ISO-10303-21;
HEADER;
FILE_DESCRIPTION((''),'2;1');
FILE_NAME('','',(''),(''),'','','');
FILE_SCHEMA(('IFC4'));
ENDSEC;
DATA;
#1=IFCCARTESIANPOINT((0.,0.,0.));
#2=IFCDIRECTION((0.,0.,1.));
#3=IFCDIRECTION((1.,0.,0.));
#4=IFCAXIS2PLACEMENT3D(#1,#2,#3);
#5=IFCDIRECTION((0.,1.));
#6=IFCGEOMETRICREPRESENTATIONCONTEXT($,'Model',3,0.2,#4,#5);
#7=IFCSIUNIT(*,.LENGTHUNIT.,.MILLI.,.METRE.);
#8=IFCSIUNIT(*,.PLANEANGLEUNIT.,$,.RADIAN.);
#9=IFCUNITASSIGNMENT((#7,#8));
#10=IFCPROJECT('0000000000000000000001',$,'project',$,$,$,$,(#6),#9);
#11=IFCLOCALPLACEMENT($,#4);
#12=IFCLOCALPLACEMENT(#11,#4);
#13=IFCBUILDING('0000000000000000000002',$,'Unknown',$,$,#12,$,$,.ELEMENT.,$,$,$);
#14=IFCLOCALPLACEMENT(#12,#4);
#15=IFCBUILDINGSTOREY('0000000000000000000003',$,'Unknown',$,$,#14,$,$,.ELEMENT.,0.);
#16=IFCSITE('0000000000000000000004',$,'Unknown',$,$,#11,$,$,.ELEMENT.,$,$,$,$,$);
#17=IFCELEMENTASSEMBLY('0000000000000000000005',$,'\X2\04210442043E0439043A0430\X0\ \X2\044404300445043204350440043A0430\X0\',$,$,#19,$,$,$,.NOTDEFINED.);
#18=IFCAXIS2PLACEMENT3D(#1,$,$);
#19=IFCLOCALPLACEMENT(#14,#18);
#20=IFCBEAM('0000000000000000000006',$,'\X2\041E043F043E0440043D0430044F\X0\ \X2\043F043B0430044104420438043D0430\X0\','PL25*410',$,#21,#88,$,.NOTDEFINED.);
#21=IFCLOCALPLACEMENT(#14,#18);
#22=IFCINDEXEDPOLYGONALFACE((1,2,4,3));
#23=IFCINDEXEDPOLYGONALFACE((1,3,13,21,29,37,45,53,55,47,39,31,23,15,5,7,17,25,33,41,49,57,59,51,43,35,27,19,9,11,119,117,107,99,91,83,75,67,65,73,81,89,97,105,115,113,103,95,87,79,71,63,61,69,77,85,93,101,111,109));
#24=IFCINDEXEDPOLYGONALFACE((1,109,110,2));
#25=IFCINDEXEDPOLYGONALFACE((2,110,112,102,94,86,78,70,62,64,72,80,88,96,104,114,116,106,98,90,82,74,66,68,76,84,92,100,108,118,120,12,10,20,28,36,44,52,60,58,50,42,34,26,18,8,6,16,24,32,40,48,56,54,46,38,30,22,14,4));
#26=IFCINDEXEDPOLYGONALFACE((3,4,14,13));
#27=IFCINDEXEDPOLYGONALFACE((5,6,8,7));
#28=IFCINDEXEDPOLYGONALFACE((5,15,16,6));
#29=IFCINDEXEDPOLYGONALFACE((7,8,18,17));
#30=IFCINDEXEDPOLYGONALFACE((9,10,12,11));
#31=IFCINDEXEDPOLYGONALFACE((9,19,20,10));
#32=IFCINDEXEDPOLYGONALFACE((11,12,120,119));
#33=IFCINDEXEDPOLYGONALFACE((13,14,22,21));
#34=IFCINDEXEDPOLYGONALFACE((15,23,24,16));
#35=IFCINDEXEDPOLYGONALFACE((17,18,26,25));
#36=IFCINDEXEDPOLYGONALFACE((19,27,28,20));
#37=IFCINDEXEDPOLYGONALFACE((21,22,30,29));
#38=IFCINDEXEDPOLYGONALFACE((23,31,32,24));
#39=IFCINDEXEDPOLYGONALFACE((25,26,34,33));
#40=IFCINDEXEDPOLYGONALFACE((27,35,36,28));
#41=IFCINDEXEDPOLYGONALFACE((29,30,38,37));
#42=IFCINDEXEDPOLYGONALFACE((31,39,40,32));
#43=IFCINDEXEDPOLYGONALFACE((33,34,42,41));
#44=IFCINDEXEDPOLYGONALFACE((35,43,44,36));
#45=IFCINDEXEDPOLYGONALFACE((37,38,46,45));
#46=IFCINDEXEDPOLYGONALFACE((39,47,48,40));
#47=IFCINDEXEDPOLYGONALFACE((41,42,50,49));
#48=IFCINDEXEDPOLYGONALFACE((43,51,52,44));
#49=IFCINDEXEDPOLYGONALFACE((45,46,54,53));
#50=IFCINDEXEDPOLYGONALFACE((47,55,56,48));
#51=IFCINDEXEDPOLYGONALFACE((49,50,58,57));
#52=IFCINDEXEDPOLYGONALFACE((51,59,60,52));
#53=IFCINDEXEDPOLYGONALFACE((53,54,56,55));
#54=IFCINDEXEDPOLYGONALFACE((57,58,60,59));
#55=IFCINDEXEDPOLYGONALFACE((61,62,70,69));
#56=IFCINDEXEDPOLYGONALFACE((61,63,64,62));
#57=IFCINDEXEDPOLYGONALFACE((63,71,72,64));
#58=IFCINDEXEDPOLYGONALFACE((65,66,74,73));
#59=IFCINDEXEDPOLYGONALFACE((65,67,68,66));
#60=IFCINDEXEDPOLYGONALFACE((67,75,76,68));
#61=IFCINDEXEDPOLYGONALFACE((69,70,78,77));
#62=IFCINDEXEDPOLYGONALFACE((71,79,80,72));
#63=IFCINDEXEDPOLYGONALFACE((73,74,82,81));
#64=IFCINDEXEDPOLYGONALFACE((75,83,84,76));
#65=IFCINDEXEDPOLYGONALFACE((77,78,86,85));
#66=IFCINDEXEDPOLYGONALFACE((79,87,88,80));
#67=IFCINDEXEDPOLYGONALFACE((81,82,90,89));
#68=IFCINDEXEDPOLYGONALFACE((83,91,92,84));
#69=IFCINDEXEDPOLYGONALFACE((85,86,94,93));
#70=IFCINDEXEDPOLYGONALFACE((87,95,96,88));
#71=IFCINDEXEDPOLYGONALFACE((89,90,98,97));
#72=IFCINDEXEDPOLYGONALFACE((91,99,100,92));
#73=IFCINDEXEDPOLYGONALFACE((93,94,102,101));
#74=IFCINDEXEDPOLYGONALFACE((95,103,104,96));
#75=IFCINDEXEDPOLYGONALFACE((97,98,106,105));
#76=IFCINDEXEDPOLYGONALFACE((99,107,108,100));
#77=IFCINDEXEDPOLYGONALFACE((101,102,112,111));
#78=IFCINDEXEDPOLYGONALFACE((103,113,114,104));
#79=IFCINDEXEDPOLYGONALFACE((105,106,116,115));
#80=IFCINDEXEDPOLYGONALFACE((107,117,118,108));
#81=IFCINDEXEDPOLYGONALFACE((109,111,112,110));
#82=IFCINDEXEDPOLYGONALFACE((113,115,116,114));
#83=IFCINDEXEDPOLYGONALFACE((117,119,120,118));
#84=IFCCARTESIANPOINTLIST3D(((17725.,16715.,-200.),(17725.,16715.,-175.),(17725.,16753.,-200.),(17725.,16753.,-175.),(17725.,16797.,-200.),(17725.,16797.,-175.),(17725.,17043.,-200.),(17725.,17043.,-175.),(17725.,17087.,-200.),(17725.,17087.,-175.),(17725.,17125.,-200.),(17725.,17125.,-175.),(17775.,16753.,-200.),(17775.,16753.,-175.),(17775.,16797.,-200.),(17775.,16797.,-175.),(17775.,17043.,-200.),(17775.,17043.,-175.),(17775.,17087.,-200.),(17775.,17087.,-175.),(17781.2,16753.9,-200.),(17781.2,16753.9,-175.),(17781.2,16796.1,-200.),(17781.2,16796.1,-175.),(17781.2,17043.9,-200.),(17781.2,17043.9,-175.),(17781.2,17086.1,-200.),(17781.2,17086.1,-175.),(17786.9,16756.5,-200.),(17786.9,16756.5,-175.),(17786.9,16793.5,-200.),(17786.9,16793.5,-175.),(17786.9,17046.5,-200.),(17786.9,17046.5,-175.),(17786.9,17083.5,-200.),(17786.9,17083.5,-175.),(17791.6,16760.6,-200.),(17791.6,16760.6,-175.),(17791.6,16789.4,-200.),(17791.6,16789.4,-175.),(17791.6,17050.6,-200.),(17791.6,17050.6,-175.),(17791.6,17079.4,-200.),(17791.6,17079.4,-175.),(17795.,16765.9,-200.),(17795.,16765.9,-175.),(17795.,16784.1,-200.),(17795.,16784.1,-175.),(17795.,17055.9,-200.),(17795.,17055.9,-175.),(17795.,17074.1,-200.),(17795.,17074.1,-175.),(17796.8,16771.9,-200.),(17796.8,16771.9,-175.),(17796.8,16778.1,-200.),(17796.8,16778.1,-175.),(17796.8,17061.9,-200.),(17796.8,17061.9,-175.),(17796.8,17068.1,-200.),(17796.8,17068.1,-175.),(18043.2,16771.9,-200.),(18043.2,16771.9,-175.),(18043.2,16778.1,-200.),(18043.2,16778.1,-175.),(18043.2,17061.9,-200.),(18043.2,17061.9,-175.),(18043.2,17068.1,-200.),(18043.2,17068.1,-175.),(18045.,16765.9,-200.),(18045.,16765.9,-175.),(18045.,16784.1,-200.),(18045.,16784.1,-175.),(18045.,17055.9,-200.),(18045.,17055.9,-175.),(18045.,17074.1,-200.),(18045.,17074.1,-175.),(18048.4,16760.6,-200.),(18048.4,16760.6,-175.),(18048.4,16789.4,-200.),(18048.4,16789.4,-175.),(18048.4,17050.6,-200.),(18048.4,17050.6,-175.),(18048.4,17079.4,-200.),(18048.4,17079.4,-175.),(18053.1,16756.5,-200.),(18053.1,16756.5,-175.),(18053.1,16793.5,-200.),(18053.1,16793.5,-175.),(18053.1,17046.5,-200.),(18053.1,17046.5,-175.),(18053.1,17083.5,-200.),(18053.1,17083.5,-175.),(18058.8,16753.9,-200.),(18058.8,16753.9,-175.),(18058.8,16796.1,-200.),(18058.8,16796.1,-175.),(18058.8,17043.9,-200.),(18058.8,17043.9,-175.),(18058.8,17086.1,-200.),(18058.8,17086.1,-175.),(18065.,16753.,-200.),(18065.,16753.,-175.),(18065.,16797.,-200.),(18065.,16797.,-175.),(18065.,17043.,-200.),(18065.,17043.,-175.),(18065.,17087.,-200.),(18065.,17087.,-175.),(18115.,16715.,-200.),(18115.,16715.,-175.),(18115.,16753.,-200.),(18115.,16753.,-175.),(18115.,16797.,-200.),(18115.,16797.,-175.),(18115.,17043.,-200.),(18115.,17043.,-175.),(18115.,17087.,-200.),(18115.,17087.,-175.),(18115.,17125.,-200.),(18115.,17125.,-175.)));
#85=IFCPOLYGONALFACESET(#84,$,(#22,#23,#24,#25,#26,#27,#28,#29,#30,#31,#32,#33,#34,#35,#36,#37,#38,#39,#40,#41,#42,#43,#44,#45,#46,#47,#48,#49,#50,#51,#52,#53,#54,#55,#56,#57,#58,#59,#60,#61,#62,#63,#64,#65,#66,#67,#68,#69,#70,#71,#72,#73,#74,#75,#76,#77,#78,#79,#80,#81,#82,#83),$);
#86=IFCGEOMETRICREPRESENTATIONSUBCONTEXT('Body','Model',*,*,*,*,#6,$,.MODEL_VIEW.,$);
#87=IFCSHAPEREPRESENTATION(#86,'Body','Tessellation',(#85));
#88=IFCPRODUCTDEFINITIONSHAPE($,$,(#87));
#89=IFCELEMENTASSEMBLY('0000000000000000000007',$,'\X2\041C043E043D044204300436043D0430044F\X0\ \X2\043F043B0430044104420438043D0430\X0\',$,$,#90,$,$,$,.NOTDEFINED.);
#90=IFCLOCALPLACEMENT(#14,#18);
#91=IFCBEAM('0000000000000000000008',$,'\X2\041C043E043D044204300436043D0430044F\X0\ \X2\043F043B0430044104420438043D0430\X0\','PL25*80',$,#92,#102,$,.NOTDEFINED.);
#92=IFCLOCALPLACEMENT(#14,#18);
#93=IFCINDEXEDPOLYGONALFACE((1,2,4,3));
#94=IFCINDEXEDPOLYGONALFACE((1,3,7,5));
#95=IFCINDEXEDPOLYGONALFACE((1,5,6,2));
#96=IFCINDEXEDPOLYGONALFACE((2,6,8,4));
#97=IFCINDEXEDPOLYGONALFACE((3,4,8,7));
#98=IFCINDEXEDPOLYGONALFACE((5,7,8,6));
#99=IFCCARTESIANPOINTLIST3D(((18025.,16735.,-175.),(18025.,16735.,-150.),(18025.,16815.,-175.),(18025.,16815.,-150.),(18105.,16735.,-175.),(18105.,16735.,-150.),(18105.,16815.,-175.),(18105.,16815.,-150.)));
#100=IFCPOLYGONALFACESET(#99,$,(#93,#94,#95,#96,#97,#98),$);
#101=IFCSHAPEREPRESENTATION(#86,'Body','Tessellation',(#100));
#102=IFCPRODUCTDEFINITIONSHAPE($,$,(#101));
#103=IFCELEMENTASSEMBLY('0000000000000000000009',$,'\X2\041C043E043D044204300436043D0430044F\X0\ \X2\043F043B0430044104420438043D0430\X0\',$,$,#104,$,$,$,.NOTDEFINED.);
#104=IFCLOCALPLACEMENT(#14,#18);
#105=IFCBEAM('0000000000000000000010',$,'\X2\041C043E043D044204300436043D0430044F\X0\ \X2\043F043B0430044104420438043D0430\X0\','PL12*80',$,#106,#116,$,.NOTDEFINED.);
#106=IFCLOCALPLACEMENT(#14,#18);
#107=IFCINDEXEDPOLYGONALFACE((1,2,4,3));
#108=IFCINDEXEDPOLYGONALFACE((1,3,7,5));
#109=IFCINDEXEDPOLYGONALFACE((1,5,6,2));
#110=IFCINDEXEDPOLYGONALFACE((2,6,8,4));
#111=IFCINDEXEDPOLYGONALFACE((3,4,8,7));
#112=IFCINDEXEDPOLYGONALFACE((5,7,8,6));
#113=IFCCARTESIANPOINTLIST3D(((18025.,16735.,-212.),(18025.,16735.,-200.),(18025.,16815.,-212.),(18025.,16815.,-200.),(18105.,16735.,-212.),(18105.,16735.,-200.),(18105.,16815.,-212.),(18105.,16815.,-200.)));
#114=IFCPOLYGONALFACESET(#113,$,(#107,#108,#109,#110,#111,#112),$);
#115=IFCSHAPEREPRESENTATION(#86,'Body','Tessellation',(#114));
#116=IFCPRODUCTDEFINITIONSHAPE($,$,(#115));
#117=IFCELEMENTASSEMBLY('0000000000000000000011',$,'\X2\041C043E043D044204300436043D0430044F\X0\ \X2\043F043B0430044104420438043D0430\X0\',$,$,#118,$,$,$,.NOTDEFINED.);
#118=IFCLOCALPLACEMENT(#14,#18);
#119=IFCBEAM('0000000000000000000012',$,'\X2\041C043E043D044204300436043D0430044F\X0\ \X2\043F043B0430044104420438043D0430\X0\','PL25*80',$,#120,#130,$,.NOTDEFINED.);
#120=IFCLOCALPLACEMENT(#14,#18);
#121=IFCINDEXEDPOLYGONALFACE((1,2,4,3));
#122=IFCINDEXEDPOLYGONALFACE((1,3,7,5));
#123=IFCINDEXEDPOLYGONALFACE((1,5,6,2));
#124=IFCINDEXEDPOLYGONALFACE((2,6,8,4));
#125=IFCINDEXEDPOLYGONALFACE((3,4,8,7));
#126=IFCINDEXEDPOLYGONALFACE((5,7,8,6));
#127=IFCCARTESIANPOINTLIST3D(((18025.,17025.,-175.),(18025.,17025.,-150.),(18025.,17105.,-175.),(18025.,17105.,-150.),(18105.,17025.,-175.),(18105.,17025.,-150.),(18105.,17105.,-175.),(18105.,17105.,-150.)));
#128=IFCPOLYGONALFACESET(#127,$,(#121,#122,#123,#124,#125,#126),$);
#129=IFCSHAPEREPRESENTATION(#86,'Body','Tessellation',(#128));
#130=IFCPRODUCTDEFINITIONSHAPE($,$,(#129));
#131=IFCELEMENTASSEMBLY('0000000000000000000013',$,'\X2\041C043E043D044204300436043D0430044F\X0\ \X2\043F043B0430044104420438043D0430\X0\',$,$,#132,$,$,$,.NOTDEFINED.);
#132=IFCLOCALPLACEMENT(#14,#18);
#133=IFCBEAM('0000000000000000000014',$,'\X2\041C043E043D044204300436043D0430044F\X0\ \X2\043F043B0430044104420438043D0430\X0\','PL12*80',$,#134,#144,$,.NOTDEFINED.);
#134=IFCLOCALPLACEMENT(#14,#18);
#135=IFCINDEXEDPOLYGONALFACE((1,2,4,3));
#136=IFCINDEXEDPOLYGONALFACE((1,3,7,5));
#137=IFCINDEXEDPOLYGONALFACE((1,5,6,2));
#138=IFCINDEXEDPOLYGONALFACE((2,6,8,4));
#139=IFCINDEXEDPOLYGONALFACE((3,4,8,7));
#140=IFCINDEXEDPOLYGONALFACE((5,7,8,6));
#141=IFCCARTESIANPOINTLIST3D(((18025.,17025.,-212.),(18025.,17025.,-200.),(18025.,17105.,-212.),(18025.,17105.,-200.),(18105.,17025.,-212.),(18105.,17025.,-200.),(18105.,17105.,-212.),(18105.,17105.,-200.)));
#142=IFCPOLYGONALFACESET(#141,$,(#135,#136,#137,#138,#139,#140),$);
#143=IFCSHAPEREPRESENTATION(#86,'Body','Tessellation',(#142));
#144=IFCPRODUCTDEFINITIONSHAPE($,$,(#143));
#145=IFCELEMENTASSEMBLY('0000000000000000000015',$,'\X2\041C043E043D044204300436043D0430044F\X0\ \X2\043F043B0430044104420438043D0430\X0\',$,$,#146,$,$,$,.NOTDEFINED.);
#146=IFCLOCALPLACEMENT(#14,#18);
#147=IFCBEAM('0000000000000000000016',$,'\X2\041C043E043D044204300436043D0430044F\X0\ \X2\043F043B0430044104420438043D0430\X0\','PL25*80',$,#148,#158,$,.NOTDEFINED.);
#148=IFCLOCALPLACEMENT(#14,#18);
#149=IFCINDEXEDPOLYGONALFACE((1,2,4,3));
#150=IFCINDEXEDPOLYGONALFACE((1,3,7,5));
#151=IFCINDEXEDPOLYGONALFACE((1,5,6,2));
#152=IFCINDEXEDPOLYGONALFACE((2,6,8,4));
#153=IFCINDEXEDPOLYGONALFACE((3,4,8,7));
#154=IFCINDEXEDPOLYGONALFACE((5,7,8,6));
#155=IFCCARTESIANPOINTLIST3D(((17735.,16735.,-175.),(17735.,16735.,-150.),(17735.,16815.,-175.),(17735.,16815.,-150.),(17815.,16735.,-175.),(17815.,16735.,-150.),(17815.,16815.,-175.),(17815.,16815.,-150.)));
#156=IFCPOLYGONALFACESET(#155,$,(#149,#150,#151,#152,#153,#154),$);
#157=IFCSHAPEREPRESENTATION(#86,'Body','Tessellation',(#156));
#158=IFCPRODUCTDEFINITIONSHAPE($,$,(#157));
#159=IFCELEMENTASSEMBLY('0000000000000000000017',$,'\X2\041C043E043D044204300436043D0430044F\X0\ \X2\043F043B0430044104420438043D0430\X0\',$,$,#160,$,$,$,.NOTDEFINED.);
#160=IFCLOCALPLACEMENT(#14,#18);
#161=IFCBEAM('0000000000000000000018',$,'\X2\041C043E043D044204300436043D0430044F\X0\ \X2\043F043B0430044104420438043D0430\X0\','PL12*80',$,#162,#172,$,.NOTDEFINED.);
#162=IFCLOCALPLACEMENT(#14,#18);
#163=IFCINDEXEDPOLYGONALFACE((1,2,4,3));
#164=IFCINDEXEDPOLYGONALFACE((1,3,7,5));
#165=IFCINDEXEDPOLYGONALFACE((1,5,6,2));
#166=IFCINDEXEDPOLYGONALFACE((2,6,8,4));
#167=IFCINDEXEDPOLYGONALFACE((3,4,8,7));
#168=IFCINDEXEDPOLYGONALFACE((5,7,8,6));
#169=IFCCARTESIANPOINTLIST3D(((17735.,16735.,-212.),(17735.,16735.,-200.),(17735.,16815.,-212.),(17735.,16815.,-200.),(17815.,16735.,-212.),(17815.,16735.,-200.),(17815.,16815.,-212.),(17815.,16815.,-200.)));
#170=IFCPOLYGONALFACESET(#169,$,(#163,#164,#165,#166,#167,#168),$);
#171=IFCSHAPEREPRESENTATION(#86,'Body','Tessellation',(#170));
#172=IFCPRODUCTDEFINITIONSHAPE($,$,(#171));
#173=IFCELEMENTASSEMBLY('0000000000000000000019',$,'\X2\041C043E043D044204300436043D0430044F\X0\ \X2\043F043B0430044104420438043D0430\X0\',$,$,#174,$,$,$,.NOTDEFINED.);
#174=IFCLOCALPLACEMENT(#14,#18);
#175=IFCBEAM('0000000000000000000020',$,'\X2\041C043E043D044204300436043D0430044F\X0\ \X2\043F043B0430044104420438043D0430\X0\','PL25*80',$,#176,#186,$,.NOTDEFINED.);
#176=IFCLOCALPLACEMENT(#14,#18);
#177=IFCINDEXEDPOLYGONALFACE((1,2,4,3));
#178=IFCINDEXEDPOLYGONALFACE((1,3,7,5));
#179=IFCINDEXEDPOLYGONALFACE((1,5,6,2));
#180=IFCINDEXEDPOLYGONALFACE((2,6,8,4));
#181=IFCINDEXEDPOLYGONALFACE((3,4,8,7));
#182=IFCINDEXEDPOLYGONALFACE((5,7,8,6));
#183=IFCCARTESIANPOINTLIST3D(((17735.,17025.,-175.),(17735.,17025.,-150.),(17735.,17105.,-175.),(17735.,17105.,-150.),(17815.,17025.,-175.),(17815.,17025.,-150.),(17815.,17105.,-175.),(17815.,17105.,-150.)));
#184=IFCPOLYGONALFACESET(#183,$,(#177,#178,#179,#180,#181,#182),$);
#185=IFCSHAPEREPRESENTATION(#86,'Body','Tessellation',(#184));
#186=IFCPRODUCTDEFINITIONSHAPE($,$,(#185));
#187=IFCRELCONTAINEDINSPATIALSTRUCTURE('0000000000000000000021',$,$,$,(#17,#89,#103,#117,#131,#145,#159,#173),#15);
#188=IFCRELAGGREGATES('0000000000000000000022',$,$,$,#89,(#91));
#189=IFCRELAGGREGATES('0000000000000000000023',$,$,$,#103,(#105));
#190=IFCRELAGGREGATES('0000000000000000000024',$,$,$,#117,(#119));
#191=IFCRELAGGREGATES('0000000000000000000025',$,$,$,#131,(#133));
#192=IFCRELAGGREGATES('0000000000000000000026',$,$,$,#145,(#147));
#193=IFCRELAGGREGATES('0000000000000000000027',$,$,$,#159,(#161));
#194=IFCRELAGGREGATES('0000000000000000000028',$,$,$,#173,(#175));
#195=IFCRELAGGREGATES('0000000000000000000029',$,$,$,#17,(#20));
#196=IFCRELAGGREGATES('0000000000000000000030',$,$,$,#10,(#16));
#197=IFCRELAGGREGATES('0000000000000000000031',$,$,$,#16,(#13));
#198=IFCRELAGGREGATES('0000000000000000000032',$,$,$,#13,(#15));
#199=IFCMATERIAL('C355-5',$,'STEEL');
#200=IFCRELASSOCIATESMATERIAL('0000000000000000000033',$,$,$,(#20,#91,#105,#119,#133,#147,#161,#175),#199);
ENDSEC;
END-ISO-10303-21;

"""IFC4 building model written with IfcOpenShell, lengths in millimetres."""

from ifc_helpers import new_model, si_unit, direction, frame, origin_with_axes, place, context, subcontext, project, spatial, line, arc, indexed_curve, outline, extrude, material, element, aggregate, save


model = new_model("IFC4")

# Units and contexts
model_context = context("Model", 3, precision=0.2, world=origin_with_axes(), true_north=direction((0.0, 1.0)))
body_context = subcontext(model_context, "Body", "Model", "MODEL_VIEW")
ifc_project = project(units=[si_unit("LENGTHUNIT", "METRE", prefix="MILLI"), si_unit("PLANEANGLEUNIT", "RADIAN")], contexts=[model_context])

# Site, building, storey
site_placement = place(None, origin_with_axes())
site = spatial("IfcSite", under=ifc_project, at=site_placement, Name="Unknown", CompositionType="ELEMENT")
building_placement = place(site_placement, origin_with_axes())
building = spatial("IfcBuilding", under=site, at=building_placement, Name="Unknown", CompositionType="ELEMENT")
storey_placement = place(building_placement, origin_with_axes())
storey = spatial("IfcBuildingStorey", under=building, at=storey_placement, Name="Unknown", CompositionType="ELEMENT", Elevation=0.0)

# Shared definitions
ifc_material_1 = material(Name="C355-5", Category="STEEL")

# Element assembly, beam, voiding features
assembly_1_placement = place(storey_placement, frame((17920.0, 16920.0, -200.0), z_axis=(0.0, -1.0, 0.0), x_axis=(0.0, 0.0, 1.0)))
assembly_1 = element("IfcElementAssembly", 1, at=assembly_1_placement, inside=storey, Name="Стойка фахверка", PredefinedType="NOTDEFINED")
beam_1_placement = place(assembly_1_placement, frame((12.5, 195.0, 0.0), z_axis=(-1.0, 0.0, 0.0), x_axis=(0.0, -1.0, 0.0)))
beam_1 = element("IfcBeam", 2, at=beam_1_placement, material=ifc_material_1, Name="Опорная пластина", Description="PL25*410", PredefinedType="NOTDEFINED", context=body_context, shape_type="SolidModel", body=[
    extrude(outline(indexed_curve([(-12.5, -205.0), (12.5, -205.0), (12.5, 205.0), (-12.5, 205.0)], segments=[line(1, 2, 3, 4, 1)])), frame((0.0, 0.0, 0.0), z_axis=(-1.0, 0.0, 0.0), x_axis=(0.0, 0.0, 1.0)), (0.0, 0.0, -1.0), 390.0),
])
voiding_feature_1_placement = place(beam_1_placement, frame((390.0, 167.0, 0.0), z_axis=(0.0, 0.0, -1.0), x_axis=(0.0, -1.0, 0.0)))
element("IfcVoidingFeature", 3, at=voiding_feature_1_placement, cuts=beam_1, Name="Пластина", PredefinedType="HOLE", context=body_context, shape_type="SolidModel", body=[
    extrude(outline(indexed_curve([(0.0, 0.0), (44.0, 0.0), (44.0, 50.0), (37.6, 65.6), (22.0, 72.0), (22.0, 72.0), (6.4, 65.6), (0.0, 50.0)], segments=[line(1, 2, 3), arc(3, 4, 5), line(5, 6), arc(6, 7, 8), line(8, 1)])), frame((0.0, 0.0, 12.5), z_axis=(0.0, 0.0, 1.0), x_axis=(1.0, 0.0, 0.0)), (0.0, 0.0, -1.0), 25.0),
])
voiding_feature_2_placement = place(beam_1_placement, frame((390.0, -167.0, 0.0), z_axis=(0.0, 0.0, 1.0), x_axis=(0.0, 1.0, 0.0)))
element("IfcVoidingFeature", 4, at=voiding_feature_2_placement, cuts=beam_1, Name="Пластина", PredefinedType="HOLE", context=body_context, shape_type="SolidModel", body=[
    extrude(outline(indexed_curve([(0.0, 0.0), (44.0, 0.0), (44.0, 50.0), (37.6, 65.6), (22.0, 72.0), (22.0, 72.0), (6.4, 65.6), (0.0, 50.0)], segments=[line(1, 2, 3), arc(3, 4, 5), line(5, 6), arc(6, 7, 8), line(8, 1)])), frame((0.0, 0.0, 12.5), z_axis=(0.0, 0.0, 1.0), x_axis=(1.0, 0.0, 0.0)), (0.0, 0.0, -1.0), 25.0),
])
voiding_feature_3_placement = place(beam_1_placement, frame((0.0, 167.0, 0.0), z_axis=(0.0, 0.0, 1.0), x_axis=(0.0, -1.0, 0.0)))
element("IfcVoidingFeature", 5, at=voiding_feature_3_placement, cuts=beam_1, Name="Пластина", PredefinedType="HOLE", context=body_context, shape_type="SolidModel", body=[
    extrude(outline(indexed_curve([(0.0, 0.0), (44.0, 0.0), (44.0, 50.0), (37.6, 65.6), (22.0, 72.0), (22.0, 72.0), (6.4, 65.6), (0.0, 50.0)], segments=[line(1, 2, 3), arc(3, 4, 5), line(5, 6), arc(6, 7, 8), line(8, 1)])), frame((0.0, 0.0, 12.5), z_axis=(0.0, 0.0, 1.0), x_axis=(1.0, 0.0, 0.0)), (0.0, 0.0, -1.0), 25.0),
])
voiding_feature_4_placement = place(beam_1_placement, frame((0.0, -167.0, 0.0), z_axis=(0.0, 0.0, -1.0), x_axis=(0.0, 1.0, 0.0)))
element("IfcVoidingFeature", 6, at=voiding_feature_4_placement, cuts=beam_1, Name="Пластина", PredefinedType="HOLE", context=body_context, shape_type="SolidModel", body=[
    extrude(outline(indexed_curve([(0.0, 0.0), (44.0, 0.0), (44.0, 50.0), (37.6, 65.6), (22.0, 72.0), (22.0, 72.0), (6.4, 65.6), (0.0, 50.0)], segments=[line(1, 2, 3), arc(3, 4, 5), line(5, 6), arc(6, 7, 8), line(8, 1)])), frame((0.0, 0.0, 12.5), z_axis=(0.0, 0.0, 1.0), x_axis=(1.0, 0.0, 0.0)), (0.0, 0.0, -1.0), 25.0),
])

# Element assemblies, beams
assembly_2_placement = place(storey_placement, frame((18025.0, 16775.0, -162.5), z_axis=(0.0, 0.0, -1.0), x_axis=(1.0, 0.0, 0.0)))
assembly_2 = element("IfcElementAssembly", 7, at=assembly_2_placement, inside=storey, Name="Монтажная пластина", PredefinedType="NOTDEFINED")
beam_2_placement = place(assembly_2_placement, origin_with_axes())
beam_2 = element("IfcBeam", 8, at=beam_2_placement, material=ifc_material_1, Name="Монтажная пластина", Description="PL25*80", PredefinedType="NOTDEFINED", context=body_context, shape_type="SolidModel", body=[
    extrude(outline(indexed_curve([(-12.5, -40.0), (12.5, -40.0), (12.5, 40.0), (-12.5, 40.0)], segments=[line(1, 2, 3, 4, 1)])), frame((0.0, 0.0, 0.0), z_axis=(-1.0, 0.0, 0.0), x_axis=(0.0, 0.0, 1.0)), (0.0, 0.0, -1.0), 80.0),
])
aggregate(assembly_2, [beam_2])
assembly_3_placement = place(storey_placement, frame((18025.0, 16775.0, -206.0), z_axis=(0.0, 0.0, -1.0), x_axis=(1.0, 0.0, 0.0)))
assembly_3 = element("IfcElementAssembly", 9, at=assembly_3_placement, inside=storey, Name="Монтажная пластина", PredefinedType="NOTDEFINED")
beam_3_placement = place(assembly_3_placement, origin_with_axes())
beam_3 = element("IfcBeam", 10, at=beam_3_placement, material=ifc_material_1, Name="Монтажная пластина", Description="PL12*80", PredefinedType="NOTDEFINED", context=body_context, shape_type="SolidModel", body=[
    extrude(outline(indexed_curve([(-6.0, -40.0), (6.0, -40.0), (6.0, 40.0), (-6.0, 40.0)], segments=[line(1, 2, 3, 4, 1)])), frame((0.0, 0.0, 0.0), z_axis=(-1.0, 0.0, 0.0), x_axis=(0.0, 0.0, 1.0)), (0.0, 0.0, -1.0), 80.0),
])
aggregate(assembly_3, [beam_3])
assembly_4_placement = place(storey_placement, frame((18025.0, 17065.0, -162.5), z_axis=(0.0, 0.0, -1.0), x_axis=(1.0, 0.0, 0.0)))
assembly_4 = element("IfcElementAssembly", 11, at=assembly_4_placement, inside=storey, Name="Монтажная пластина", PredefinedType="NOTDEFINED")
beam_4_placement = place(assembly_4_placement, origin_with_axes())
beam_4 = element("IfcBeam", 12, at=beam_4_placement, material=ifc_material_1, Name="Монтажная пластина", Description="PL25*80", PredefinedType="NOTDEFINED", context=body_context, shape_type="SolidModel", body=[
    extrude(outline(indexed_curve([(-12.5, -40.0), (12.5, -40.0), (12.5, 40.0), (-12.5, 40.0)], segments=[line(1, 2, 3, 4, 1)])), frame((0.0, 0.0, 0.0), z_axis=(-1.0, 0.0, 0.0), x_axis=(0.0, 0.0, 1.0)), (0.0, 0.0, -1.0), 80.0),
])
aggregate(assembly_4, [beam_4])
assembly_5_placement = place(storey_placement, frame((18025.0, 17065.0, -206.0), z_axis=(0.0, 0.0, -1.0), x_axis=(1.0, 0.0, 0.0)))
assembly_5 = element("IfcElementAssembly", 13, at=assembly_5_placement, inside=storey, Name="Монтажная пластина", PredefinedType="NOTDEFINED")
beam_5_placement = place(assembly_5_placement, origin_with_axes())
beam_5 = element("IfcBeam", 14, at=beam_5_placement, material=ifc_material_1, Name="Монтажная пластина", Description="PL12*80", PredefinedType="NOTDEFINED", context=body_context, shape_type="SolidModel", body=[
    extrude(outline(indexed_curve([(-6.0, -40.0), (6.0, -40.0), (6.0, 40.0), (-6.0, 40.0)], segments=[line(1, 2, 3, 4, 1)])), frame((0.0, 0.0, 0.0), z_axis=(-1.0, 0.0, 0.0), x_axis=(0.0, 0.0, 1.0)), (0.0, 0.0, -1.0), 80.0),
])
aggregate(assembly_5, [beam_5])
assembly_6_placement = place(storey_placement, frame((17735.0, 16775.0, -162.5), z_axis=(0.0, 0.0, -1.0), x_axis=(1.0, 0.0, 0.0)))
assembly_6 = element("IfcElementAssembly", 15, at=assembly_6_placement, inside=storey, Name="Монтажная пластина", PredefinedType="NOTDEFINED")
beam_6_placement = place(assembly_6_placement, origin_with_axes())
beam_6 = element("IfcBeam", 16, at=beam_6_placement, material=ifc_material_1, Name="Монтажная пластина", Description="PL25*80", PredefinedType="NOTDEFINED", context=body_context, shape_type="SolidModel", body=[
    extrude(outline(indexed_curve([(-12.5, -40.0), (12.5, -40.0), (12.5, 40.0), (-12.5, 40.0)], segments=[line(1, 2, 3, 4, 1)])), frame((0.0, 0.0, 0.0), z_axis=(-1.0, 0.0, 0.0), x_axis=(0.0, 0.0, 1.0)), (0.0, 0.0, -1.0), 80.0),
])
aggregate(assembly_6, [beam_6])
assembly_7_placement = place(storey_placement, frame((17735.0, 16775.0, -206.0), z_axis=(0.0, 0.0, -1.0), x_axis=(1.0, 0.0, 0.0)))
assembly_7 = element("IfcElementAssembly", 17, at=assembly_7_placement, inside=storey, Name="Монтажная пластина", PredefinedType="NOTDEFINED")
beam_7_placement = place(assembly_7_placement, origin_with_axes())
beam_7 = element("IfcBeam", 18, at=beam_7_placement, material=ifc_material_1, Name="Монтажная пластина", Description="PL12*80", PredefinedType="NOTDEFINED", context=body_context, shape_type="SolidModel", body=[
    extrude(outline(indexed_curve([(-6.0, -40.0), (6.0, -40.0), (6.0, 40.0), (-6.0, 40.0)], segments=[line(1, 2, 3, 4, 1)])), frame((0.0, 0.0, 0.0), z_axis=(-1.0, 0.0, 0.0), x_axis=(0.0, 0.0, 1.0)), (0.0, 0.0, -1.0), 80.0),
])
aggregate(assembly_7, [beam_7])
assembly_8_placement = place(storey_placement, frame((17735.0, 17065.0, -162.5), z_axis=(0.0, 0.0, -1.0), x_axis=(1.0, 0.0, 0.0)))
assembly_8 = element("IfcElementAssembly", 19, at=assembly_8_placement, inside=storey, Name="Монтажная пластина", PredefinedType="NOTDEFINED")
beam_8_placement = place(assembly_8_placement, origin_with_axes())
beam_8 = element("IfcBeam", 20, at=beam_8_placement, material=ifc_material_1, Name="Монтажная пластина", Description="PL25*80", PredefinedType="NOTDEFINED", context=body_context, shape_type="SolidModel", body=[
    extrude(outline(indexed_curve([(-12.5, -40.0), (12.5, -40.0), (12.5, 40.0), (-12.5, 40.0)], segments=[line(1, 2, 3, 4, 1)])), frame((0.0, 0.0, 0.0), z_axis=(-1.0, 0.0, 0.0), x_axis=(0.0, 0.0, 1.0)), (0.0, 0.0, -1.0), 80.0),
])
aggregate(assembly_8, [beam_8])

aggregate(assembly_1, [beam_1])

save(model, "model.ifc")
